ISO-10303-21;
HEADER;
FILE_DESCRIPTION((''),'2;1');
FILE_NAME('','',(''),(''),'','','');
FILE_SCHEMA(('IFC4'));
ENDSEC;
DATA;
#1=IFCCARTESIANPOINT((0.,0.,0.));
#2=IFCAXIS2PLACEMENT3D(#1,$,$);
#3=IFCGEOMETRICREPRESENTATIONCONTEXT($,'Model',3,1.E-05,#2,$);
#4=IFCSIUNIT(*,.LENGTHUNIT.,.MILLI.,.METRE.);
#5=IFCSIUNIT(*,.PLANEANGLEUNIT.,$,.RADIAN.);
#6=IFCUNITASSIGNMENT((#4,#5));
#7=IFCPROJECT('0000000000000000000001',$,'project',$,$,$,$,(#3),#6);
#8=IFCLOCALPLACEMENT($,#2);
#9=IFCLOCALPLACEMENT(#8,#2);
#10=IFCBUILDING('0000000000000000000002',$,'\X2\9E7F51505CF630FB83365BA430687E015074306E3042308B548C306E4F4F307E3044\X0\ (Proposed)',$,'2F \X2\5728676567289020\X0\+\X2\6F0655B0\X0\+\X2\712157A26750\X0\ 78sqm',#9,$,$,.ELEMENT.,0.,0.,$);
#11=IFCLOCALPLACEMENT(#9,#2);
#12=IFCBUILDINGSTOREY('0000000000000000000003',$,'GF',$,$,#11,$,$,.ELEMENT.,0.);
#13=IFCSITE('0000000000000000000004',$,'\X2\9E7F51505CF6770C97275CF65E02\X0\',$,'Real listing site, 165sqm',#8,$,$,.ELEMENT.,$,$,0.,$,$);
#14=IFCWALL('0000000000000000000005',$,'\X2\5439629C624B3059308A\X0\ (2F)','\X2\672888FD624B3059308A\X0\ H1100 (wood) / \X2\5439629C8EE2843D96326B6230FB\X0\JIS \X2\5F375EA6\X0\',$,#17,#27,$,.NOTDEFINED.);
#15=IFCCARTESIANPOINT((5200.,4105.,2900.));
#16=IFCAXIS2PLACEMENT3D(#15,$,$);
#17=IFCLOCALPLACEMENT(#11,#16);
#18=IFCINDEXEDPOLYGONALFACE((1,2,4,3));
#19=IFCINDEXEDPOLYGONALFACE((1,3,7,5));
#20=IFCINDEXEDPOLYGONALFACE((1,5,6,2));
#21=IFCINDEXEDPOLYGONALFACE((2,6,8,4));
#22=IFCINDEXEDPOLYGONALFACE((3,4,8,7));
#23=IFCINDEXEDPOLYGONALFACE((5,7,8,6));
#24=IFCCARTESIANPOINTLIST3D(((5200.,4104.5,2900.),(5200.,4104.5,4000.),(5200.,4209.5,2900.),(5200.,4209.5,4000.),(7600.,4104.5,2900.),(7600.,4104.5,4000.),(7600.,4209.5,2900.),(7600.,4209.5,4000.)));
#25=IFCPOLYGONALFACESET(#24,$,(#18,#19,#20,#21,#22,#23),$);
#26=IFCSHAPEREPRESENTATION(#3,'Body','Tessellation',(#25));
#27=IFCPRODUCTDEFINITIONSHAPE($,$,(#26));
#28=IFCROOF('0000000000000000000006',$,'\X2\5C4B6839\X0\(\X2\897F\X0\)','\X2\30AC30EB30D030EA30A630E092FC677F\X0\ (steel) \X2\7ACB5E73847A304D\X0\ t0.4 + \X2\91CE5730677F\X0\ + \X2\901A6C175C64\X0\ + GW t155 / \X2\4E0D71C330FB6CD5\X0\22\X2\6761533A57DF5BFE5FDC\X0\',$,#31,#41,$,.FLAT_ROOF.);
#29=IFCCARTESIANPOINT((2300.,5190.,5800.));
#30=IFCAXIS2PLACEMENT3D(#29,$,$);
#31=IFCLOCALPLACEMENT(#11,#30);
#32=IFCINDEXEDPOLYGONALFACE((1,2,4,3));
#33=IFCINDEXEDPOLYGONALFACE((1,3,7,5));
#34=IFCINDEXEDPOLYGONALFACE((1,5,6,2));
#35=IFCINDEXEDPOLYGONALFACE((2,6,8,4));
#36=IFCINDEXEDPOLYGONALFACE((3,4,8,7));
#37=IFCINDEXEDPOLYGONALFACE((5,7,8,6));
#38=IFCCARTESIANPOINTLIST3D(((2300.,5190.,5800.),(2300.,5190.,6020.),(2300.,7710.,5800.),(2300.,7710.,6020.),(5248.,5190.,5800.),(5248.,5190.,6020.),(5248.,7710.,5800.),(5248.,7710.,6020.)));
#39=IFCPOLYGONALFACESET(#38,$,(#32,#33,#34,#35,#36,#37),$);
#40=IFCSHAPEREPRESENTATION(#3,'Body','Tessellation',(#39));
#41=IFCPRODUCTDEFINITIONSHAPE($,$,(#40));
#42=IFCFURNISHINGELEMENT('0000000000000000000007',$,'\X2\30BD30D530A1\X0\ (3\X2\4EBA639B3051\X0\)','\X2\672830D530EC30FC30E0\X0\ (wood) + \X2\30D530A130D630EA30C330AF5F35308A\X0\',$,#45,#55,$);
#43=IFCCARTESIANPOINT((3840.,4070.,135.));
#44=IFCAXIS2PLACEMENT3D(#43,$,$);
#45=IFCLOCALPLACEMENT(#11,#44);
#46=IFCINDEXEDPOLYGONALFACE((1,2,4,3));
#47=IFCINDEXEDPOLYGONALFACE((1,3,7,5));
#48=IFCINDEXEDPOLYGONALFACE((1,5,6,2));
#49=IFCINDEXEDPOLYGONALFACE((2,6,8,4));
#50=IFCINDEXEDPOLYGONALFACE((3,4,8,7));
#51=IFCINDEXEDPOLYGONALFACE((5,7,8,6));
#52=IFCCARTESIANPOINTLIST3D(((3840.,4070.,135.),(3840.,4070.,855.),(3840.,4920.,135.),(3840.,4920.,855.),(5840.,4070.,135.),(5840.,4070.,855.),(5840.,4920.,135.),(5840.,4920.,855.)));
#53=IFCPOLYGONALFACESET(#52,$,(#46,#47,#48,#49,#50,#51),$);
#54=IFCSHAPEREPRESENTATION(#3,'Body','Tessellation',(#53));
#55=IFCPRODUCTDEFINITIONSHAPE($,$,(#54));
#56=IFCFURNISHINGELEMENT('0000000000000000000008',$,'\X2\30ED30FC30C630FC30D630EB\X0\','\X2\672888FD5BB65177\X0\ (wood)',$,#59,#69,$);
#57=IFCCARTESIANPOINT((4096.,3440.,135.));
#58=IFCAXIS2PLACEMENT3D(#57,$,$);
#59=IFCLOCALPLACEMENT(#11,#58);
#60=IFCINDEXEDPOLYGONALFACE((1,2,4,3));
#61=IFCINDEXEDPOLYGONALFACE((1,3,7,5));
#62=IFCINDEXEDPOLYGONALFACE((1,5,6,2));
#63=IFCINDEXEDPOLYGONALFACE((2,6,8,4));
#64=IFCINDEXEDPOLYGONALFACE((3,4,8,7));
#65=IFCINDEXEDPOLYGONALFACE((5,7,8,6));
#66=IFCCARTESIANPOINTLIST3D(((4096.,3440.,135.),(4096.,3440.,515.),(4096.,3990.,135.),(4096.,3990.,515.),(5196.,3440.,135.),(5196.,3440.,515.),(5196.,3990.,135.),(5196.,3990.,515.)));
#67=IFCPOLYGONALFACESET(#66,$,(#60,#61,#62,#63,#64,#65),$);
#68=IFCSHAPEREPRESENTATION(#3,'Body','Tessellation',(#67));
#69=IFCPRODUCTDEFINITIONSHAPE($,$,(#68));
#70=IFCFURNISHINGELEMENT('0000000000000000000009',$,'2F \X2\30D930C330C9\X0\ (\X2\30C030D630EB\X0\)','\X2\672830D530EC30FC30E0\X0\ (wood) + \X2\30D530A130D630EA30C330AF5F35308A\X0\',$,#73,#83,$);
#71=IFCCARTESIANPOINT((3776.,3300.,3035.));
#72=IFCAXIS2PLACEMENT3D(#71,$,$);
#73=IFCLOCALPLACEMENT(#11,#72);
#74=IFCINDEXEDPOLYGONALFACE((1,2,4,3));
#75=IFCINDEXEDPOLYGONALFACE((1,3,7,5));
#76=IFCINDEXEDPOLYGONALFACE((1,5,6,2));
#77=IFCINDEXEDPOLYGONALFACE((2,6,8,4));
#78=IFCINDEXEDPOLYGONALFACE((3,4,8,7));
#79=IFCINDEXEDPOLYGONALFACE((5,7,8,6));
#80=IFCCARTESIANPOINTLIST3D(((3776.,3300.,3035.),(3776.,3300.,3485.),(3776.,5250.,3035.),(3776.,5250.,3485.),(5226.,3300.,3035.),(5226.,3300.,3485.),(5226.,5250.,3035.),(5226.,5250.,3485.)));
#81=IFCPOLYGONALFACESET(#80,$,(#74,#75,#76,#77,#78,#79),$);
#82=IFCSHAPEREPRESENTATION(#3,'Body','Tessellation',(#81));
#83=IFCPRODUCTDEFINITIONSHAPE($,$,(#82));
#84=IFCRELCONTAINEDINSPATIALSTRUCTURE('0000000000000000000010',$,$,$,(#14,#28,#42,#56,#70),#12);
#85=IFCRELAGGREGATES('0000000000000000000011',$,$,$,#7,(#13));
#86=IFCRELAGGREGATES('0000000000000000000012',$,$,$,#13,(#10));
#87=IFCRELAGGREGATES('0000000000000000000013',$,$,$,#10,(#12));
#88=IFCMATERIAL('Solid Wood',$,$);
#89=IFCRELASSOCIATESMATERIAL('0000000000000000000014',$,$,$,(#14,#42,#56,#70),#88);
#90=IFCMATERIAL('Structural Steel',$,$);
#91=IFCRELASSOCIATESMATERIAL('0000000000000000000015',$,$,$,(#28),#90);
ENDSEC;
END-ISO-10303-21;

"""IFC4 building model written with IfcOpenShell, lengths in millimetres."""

from ifc_helpers import new_model, si_unit, frame, frame_2d, origin, place, context, project, spatial, rectangle, extrude, material, element, save


model = new_model("IFC4")

# Units and contexts
model_context = context("Model", 3, precision=1e-05, world=origin())
ifc_project = project(units=[si_unit("LENGTHUNIT", "METRE", prefix="MILLI"), si_unit("PLANEANGLEUNIT", "RADIAN")], contexts=[model_context])

# Site, building, storey
site_placement = place(None, origin())
site = spatial("IfcSite", under=ifc_project, at=site_placement, Name="鹿児島県霧島市", ObjectType="Real listing site, 165sqm", CompositionType="ELEMENT", RefElevation=0.0)
building_placement = place(site_placement, origin())
building = spatial("IfcBuilding", under=site, at=building_placement, Name="鹿児島・茶室と縁側のある和の住まい (Proposed)", ObjectType="2F 在来木造+漆喰+無垢材 78sqm", CompositionType="ELEMENT", ElevationOfRefHeight=0.0, ElevationOfTerrain=0.0)
storey_placement = place(building_placement, origin())
storey = spatial("IfcBuildingStorey", under=building, at=storey_placement, Name="GF", CompositionType="ELEMENT", Elevation=0.0)

# Shared definitions
ifc_material_1 = material(Name="Solid Wood")

# Wall
wall_placement = place(storey_placement, frame((5200.0, 4105.0, 2900.0)))
element("IfcWall", 1, at=wall_placement, inside=storey, material=ifc_material_1, Name="吹抜手すり (2F)", Description="木製手すり H1100 (wood) / 吹抜転落防止・JIS 強度", PredefinedType="NOTDEFINED", context=model_context, shape_type="SweptSolid", body=[
    extrude(rectangle(XDim=2400.0, YDim=105.0, at=frame_2d((1200.0, 52.0))), frame((5200.0, 4105.0, 2900.0)), (0.0, 0.0, 1.0), 1100.0),
])

# Roof
ifc_material_2 = material(Name="Structural Steel")
for number, where, name in (
    (2, (2300.0, 5190.0, 5800.0), "屋根(西)"),
):
    element("IfcRoof", number, at=place(storey_placement, frame(where)), inside=storey, material=ifc_material_2, Name=name, Description="ガルバリウム鋼板 (steel) 立平葺き t0.4 + 野地板 + 通気層 + GW t155 / 不燃・法22条区域対応", PredefinedType="FLAT_ROOF", context=model_context, shape_type="SweptSolid", body=[
        extrude(rectangle(XDim=2948.0, YDim=2520.0, at=frame_2d((1474.0, 1260.0))), frame((2300.0, 5190.0, 5800.0)), (0.0, 0.0, 1.0), 220.0),
    ])

# Furnishing elements
furnishing_1_placement = place(storey_placement, frame((3840.0, 4070.0, 135.0)))
element("IfcFurnishingElement", 3, at=furnishing_1_placement, inside=storey, material=ifc_material_1, Name="ソファ (3人掛け)", Description="木フレーム (wood) + ファブリック張り", context=model_context, shape_type="SweptSolid", body=[
    extrude(rectangle(XDim=2000.0, YDim=850.0, at=frame_2d((1000.0, 425.0))), frame((3840.0, 4070.0, 135.0)), (0.0, 0.0, 1.0), 720.0),
])
furnishing_2_placement = place(storey_placement, frame((4096.0, 3440.0, 135.0)))
element("IfcFurnishingElement", 4, at=furnishing_2_placement, inside=storey, material=ifc_material_1, Name="ローテーブル", Description="木製家具 (wood)", context=model_context, shape_type="SweptSolid", body=[
    extrude(rectangle(XDim=1100.0, YDim=550.0, at=frame_2d((550.0, 275.0))), frame((4096.0, 3440.0, 135.0)), (0.0, 0.0, 1.0), 380.0),
])
furnishing_3_placement = place(storey_placement, frame((3776.0, 3300.0, 3035.0)))
element("IfcFurnishingElement", 5, at=furnishing_3_placement, inside=storey, material=ifc_material_1, Name="2F ベッド (ダブル)", Description="木フレーム (wood) + ファブリック張り", context=model_context, shape_type="SweptSolid", body=[
    extrude(rectangle(XDim=1450.0, YDim=1950.0, at=frame_2d((725.0, 975.0))), frame((3776.0, 3300.0, 3035.0)), (0.0, 0.0, 1.0), 450.0),
])

save(model, "model.ifc")
